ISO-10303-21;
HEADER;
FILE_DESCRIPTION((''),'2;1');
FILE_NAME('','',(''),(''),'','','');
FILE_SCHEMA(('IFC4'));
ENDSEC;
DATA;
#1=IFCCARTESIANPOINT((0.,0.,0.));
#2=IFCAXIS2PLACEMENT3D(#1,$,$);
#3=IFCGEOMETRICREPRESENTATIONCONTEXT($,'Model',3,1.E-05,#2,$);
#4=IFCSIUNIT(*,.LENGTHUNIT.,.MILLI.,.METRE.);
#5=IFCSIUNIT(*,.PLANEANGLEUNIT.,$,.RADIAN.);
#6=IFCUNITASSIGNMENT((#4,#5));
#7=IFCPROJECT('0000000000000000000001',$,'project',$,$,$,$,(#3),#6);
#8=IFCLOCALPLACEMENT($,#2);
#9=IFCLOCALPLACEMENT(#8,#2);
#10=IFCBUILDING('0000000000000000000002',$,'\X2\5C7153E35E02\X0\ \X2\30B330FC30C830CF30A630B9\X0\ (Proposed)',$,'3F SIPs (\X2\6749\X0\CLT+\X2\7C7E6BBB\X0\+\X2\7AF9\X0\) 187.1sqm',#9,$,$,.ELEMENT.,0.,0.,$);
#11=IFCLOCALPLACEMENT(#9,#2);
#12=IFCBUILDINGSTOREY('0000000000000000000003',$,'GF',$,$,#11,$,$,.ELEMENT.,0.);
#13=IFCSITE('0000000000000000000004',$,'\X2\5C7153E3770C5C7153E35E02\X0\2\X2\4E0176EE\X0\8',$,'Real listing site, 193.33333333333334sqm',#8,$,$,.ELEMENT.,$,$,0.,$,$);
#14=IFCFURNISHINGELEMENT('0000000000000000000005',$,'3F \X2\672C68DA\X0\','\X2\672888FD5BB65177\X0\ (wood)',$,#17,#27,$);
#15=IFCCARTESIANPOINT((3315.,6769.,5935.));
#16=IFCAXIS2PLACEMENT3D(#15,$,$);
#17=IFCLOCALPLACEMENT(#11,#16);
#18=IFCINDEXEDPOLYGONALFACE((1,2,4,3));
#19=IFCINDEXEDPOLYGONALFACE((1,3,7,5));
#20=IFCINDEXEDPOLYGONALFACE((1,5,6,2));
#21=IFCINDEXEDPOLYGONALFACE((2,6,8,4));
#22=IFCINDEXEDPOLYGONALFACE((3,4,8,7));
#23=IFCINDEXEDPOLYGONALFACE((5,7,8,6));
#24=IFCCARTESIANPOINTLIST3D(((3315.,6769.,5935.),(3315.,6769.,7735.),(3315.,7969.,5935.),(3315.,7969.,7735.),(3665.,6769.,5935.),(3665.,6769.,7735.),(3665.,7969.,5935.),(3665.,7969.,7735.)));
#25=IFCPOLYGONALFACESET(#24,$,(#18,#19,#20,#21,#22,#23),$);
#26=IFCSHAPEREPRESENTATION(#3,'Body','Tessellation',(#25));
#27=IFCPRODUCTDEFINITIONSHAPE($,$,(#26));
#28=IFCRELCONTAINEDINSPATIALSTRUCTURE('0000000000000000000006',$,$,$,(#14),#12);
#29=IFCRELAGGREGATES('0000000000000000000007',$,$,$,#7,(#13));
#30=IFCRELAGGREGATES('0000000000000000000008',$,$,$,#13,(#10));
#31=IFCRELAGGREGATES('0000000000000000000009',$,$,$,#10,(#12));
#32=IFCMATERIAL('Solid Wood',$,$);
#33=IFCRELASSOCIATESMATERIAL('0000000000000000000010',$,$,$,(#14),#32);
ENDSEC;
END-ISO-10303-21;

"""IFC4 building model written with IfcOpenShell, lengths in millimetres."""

from ifc_helpers import new_model, si_unit, frame, frame_2d, origin, place, context, project, spatial, rectangle, extrude, material, element, save


model = new_model("IFC4")

# Units and contexts
model_context = context("Model", 3, precision=1e-05, world=origin())
ifc_project = project(units=[si_unit("LENGTHUNIT", "METRE", prefix="MILLI"), si_unit("PLANEANGLEUNIT", "RADIAN")], contexts=[model_context])

# Site, building, storey
site_placement = place(None, origin())
site = spatial("IfcSite", under=ifc_project, at=site_placement, Name="山口県山口市2丁目8", ObjectType="Real listing site, 193.33333333333334sqm", CompositionType="ELEMENT", RefElevation=0.0)
building_placement = place(site_placement, origin())
building = spatial("IfcBuilding", under=site, at=building_placement, Name="山口市 コートハウス (Proposed)", ObjectType="3F SIPs (杉CLT+籾殻+竹) 187.1sqm", CompositionType="ELEMENT", ElevationOfRefHeight=0.0, ElevationOfTerrain=0.0)
storey_placement = place(building_placement, origin())
storey = spatial("IfcBuildingStorey", under=building, at=storey_placement, Name="GF", CompositionType="ELEMENT", Elevation=0.0)

# Shared definitions
ifc_material_1 = material(Name="Solid Wood")

# Furnishing element
furnishing_1_placement = place(storey_placement, frame((3315.0, 6769.0, 5935.0)))
element("IfcFurnishingElement", 1, at=furnishing_1_placement, inside=storey, material=ifc_material_1, Name="3F 本棚", Description="木製家具 (wood)", context=model_context, shape_type="SweptSolid", body=[
    extrude(rectangle(XDim=350.0, YDim=1200.0, at=frame_2d((175.0, 600.0))), frame((3315.0, 6769.0, 5935.0)), (0.0, 0.0, 1.0), 1800.0),
])

save(model, "model.ifc")
